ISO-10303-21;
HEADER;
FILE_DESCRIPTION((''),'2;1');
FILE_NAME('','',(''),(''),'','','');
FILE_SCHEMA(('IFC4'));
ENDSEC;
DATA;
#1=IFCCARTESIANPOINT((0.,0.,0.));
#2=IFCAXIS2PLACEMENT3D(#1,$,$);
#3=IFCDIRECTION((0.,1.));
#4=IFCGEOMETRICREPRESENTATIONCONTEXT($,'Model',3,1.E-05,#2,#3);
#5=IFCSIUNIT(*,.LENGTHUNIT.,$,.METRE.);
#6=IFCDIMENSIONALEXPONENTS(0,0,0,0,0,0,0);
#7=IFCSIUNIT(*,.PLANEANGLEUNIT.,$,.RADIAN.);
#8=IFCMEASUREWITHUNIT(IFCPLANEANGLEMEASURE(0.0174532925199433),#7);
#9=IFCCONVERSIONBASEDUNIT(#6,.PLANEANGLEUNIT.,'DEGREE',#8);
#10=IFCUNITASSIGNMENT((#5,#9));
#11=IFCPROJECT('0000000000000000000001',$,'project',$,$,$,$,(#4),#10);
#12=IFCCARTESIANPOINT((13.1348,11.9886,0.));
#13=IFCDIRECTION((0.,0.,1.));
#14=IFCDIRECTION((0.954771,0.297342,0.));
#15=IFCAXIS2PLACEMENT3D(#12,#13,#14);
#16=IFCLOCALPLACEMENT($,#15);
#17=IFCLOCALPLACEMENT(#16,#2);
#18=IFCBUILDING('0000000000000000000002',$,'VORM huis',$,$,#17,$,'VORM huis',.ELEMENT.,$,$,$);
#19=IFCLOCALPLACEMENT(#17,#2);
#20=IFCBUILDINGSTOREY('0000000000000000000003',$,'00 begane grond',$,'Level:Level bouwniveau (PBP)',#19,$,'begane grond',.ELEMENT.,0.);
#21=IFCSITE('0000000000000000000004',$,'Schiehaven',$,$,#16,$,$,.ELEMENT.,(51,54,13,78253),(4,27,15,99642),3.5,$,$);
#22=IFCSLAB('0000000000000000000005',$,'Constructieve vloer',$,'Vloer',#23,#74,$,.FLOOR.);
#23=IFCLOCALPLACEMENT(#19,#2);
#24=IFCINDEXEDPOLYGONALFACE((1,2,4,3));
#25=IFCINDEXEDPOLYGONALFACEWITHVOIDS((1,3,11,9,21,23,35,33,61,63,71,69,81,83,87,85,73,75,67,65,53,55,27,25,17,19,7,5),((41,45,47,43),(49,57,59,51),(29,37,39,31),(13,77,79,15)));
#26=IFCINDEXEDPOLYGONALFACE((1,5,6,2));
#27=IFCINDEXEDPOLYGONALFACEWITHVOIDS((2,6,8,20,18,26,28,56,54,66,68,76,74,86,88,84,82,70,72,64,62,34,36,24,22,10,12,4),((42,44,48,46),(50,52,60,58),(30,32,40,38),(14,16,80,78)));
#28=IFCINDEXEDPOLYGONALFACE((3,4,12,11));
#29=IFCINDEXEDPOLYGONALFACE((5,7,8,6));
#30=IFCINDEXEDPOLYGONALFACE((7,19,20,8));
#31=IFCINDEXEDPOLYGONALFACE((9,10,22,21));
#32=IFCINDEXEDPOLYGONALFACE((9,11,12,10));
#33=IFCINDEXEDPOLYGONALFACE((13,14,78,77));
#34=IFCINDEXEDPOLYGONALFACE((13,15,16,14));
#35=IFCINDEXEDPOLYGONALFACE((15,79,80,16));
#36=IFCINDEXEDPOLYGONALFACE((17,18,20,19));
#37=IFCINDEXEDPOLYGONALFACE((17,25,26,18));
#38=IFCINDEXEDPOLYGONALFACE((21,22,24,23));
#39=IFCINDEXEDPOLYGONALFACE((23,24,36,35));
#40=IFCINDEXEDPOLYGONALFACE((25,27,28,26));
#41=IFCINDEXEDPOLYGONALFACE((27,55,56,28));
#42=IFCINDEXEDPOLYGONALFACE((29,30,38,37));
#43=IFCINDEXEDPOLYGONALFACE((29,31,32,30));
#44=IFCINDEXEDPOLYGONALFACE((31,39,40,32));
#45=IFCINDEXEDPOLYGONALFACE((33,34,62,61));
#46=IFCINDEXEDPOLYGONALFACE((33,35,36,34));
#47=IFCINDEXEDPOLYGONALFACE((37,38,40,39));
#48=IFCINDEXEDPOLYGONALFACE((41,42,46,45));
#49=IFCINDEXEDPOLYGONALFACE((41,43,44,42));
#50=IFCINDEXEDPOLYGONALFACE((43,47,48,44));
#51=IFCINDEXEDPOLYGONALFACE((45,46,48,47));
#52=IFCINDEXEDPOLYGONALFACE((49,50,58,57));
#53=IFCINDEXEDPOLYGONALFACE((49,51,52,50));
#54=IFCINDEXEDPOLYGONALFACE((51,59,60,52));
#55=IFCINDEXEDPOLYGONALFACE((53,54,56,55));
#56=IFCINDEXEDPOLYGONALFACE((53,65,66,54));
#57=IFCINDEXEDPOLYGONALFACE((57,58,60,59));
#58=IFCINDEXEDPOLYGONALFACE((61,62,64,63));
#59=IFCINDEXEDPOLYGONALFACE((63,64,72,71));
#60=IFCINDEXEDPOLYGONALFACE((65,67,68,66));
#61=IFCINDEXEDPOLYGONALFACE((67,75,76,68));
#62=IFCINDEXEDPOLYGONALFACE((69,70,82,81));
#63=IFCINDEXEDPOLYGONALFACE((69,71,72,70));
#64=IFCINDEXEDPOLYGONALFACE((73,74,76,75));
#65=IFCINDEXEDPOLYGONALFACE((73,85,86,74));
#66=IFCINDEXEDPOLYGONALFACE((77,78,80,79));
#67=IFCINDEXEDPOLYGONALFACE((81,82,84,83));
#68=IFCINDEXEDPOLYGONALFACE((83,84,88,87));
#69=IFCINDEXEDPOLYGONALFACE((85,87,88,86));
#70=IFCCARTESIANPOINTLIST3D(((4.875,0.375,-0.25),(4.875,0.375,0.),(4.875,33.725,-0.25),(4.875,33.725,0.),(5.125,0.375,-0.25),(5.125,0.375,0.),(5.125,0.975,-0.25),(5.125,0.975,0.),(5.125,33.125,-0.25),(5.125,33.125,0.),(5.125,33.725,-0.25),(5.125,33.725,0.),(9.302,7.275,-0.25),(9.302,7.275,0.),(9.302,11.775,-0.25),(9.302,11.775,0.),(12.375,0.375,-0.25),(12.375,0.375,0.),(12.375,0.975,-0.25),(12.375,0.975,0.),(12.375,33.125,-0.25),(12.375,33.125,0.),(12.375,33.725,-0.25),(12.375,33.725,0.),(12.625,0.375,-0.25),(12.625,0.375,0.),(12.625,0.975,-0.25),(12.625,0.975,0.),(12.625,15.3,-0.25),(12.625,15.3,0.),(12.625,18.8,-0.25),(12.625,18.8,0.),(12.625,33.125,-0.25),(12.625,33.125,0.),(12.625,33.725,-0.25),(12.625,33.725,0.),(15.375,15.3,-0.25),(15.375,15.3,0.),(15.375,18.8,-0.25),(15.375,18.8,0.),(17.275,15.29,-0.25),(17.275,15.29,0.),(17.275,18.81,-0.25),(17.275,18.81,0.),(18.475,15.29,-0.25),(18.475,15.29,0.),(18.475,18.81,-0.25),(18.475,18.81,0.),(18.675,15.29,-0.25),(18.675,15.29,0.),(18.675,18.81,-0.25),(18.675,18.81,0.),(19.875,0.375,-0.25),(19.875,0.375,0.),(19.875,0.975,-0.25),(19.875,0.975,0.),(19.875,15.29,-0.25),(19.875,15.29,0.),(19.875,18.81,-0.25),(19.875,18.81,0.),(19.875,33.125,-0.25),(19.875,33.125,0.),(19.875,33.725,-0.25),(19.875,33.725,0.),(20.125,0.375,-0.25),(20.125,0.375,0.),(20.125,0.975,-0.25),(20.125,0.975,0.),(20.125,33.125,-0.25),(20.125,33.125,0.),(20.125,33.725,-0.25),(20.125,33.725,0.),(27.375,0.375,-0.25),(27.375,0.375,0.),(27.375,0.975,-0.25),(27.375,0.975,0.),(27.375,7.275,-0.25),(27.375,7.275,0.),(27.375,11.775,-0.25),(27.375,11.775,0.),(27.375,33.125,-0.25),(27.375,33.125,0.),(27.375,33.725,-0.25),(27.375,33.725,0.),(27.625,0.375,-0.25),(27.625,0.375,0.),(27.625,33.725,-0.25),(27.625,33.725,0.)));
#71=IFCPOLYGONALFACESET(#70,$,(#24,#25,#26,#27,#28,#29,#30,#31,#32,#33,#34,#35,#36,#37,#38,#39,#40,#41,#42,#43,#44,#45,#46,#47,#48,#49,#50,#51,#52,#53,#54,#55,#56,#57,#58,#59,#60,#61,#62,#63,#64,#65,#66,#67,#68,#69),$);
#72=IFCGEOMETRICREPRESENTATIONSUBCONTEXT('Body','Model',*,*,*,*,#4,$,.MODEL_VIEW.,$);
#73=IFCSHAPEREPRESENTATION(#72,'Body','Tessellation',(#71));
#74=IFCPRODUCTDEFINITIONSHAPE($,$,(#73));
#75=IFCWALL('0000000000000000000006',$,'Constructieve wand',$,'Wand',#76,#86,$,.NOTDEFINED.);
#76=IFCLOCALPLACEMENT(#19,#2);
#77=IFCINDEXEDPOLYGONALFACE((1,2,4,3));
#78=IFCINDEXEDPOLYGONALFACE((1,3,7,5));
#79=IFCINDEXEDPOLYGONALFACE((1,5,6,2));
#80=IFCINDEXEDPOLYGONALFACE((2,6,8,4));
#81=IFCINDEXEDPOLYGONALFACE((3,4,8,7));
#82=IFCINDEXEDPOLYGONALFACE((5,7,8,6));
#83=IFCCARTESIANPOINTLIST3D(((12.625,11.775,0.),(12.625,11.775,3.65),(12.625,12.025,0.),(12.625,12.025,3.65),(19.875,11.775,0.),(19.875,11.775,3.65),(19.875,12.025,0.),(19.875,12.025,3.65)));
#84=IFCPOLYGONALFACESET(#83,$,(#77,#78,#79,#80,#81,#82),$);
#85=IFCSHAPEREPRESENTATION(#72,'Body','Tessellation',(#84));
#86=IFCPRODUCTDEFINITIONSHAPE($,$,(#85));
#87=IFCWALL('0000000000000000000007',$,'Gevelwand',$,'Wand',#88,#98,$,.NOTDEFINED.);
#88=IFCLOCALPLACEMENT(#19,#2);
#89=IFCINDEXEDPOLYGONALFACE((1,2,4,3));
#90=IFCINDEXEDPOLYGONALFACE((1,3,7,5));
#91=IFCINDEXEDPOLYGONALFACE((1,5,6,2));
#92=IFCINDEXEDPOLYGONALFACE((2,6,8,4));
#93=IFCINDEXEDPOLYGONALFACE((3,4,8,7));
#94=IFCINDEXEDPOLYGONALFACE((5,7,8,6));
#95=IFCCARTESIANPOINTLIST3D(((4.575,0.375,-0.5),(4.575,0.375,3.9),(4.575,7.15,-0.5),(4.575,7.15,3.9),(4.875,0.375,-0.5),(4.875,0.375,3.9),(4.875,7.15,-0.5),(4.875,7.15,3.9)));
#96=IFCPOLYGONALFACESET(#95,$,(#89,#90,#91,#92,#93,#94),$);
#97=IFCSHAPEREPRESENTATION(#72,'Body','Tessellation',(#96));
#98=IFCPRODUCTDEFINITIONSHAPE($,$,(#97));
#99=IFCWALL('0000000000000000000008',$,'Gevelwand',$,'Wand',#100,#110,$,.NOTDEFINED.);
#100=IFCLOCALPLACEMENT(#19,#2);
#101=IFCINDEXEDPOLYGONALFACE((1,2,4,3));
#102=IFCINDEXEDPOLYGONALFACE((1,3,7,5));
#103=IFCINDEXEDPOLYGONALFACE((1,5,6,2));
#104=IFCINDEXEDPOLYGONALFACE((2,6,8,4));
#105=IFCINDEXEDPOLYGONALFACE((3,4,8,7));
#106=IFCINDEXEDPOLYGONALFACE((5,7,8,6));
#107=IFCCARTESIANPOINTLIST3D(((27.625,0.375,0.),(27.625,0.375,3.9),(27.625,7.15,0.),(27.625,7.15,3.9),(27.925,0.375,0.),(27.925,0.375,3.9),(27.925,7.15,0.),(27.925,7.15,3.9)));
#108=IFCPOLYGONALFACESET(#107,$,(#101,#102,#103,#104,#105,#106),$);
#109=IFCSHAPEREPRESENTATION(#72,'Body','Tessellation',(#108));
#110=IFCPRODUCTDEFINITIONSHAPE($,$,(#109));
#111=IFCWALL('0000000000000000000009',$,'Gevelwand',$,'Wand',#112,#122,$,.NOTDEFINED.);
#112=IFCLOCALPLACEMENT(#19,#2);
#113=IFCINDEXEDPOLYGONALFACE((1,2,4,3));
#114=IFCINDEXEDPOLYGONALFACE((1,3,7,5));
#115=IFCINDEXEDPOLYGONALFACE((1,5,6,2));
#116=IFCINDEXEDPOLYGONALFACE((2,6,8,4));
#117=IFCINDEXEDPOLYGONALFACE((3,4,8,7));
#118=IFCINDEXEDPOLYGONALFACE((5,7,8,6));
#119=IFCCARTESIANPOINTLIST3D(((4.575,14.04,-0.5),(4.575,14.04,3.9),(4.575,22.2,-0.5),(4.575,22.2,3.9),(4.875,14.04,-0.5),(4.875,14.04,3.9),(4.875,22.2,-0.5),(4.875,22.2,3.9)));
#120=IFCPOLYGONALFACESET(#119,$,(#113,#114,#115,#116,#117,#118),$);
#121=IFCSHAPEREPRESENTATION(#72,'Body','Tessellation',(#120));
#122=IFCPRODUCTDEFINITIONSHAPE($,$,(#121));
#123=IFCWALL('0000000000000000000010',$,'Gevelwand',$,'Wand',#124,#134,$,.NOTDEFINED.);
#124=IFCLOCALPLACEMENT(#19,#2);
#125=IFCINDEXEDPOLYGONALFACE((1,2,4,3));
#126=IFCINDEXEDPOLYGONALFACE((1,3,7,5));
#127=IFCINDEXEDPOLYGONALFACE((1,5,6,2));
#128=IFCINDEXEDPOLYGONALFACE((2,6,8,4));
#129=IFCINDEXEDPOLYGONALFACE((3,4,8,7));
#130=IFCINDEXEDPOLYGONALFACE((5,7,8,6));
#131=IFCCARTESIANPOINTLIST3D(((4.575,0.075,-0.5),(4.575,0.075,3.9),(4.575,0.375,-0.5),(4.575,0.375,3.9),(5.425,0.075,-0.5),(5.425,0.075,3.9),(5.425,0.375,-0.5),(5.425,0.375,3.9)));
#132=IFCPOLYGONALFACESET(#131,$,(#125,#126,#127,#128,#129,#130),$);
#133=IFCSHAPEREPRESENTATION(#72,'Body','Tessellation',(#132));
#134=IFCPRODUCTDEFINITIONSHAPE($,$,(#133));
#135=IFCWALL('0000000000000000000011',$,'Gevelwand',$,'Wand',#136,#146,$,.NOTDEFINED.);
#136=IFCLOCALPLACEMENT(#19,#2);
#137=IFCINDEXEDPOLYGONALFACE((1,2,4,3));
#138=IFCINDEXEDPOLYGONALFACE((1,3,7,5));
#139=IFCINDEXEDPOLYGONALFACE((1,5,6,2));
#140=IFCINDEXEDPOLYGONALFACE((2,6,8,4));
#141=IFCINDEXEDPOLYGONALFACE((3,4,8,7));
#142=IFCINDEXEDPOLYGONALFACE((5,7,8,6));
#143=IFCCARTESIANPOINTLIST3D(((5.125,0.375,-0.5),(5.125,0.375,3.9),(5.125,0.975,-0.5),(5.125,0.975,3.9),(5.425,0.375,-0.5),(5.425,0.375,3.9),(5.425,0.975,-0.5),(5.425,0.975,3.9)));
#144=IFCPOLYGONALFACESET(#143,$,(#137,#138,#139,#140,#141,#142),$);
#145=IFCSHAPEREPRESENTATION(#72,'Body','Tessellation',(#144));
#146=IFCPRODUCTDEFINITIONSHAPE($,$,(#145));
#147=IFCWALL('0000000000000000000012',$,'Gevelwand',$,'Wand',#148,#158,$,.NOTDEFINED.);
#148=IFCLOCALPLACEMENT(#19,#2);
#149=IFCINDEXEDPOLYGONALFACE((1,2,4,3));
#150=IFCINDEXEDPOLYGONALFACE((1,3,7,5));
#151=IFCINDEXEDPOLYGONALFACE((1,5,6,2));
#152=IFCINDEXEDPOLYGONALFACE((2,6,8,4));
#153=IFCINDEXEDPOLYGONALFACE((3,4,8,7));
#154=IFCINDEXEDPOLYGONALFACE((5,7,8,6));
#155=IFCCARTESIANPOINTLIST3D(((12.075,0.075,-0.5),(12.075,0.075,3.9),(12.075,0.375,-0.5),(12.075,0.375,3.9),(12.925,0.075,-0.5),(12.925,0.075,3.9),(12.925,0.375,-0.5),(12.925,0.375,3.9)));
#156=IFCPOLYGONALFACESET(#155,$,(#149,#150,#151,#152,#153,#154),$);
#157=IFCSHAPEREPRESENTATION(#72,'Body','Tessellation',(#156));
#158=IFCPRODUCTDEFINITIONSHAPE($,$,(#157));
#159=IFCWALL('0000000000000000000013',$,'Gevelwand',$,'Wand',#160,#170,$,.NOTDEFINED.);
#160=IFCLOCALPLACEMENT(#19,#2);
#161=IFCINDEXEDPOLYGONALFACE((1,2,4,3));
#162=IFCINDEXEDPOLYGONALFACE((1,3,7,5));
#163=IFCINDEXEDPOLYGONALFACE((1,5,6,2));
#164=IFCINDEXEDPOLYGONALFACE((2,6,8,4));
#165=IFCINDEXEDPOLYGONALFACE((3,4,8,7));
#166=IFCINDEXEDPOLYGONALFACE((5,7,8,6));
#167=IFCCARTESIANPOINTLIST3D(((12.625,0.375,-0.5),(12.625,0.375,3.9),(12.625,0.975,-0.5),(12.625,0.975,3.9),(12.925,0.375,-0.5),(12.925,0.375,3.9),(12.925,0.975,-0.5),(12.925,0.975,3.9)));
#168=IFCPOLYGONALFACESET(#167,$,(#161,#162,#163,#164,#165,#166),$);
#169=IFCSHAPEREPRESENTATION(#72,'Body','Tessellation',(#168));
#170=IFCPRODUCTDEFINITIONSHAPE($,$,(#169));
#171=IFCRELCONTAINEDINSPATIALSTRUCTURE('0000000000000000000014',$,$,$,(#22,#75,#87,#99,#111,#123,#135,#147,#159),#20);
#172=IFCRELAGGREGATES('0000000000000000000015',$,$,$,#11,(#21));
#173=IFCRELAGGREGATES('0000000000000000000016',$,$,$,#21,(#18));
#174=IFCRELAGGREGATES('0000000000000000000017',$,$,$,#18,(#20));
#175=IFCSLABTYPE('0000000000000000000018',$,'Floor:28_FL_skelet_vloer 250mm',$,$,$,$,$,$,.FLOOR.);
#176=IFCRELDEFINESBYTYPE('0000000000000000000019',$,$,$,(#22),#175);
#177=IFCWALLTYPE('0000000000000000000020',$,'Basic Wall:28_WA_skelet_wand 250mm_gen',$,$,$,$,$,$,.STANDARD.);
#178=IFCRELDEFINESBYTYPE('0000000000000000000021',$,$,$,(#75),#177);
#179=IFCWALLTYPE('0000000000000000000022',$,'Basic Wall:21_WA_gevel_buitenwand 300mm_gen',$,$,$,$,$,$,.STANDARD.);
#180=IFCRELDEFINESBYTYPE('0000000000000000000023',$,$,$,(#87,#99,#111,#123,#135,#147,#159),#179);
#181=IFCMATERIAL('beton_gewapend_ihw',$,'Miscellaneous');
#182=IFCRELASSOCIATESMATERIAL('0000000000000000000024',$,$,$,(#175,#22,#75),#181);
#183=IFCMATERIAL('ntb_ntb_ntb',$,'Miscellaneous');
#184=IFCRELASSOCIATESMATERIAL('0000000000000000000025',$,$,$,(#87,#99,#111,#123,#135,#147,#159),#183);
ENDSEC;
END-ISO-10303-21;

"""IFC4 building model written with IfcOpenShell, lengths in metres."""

from ifc_helpers import new_model, entity, si_unit, converted_unit, direction, frame, origin, place, context, subcontext, project, spatial, indexed_curve, outline, extrude, material, type_object, element, save


model = new_model("IFC4")

# Units and contexts
model_context = context("Model", 3, precision=1e-05, world=origin(), true_north=direction((0.0, 1.0)))
body_context = subcontext(model_context, "Body", "Model", "MODEL_VIEW")
ifc_project = project(units=[si_unit("LENGTHUNIT", "METRE"), converted_unit("PLANEANGLEUNIT", "DEGREE", entity("IfcPlaneAngleMeasure", 0.0174532925199433), si_unit("PLANEANGLEUNIT", "RADIAN"), dimensions=[0, 0, 0, 0, 0, 0, 0])], contexts=[model_context])

# Site, building, storey
site_placement = place(None, frame((13.1348, 11.9886, 0.0), z_axis=(0.0, 0.0, 1.0), x_axis=(0.954771, 0.297342, 0.0)))
site = spatial("IfcSite", under=ifc_project, at=site_placement, Name="Schiehaven", CompositionType="ELEMENT", RefLatitude=(51, 54, 13, 78253), RefLongitude=(4, 27, 15, 99642), RefElevation=3.5)
building_placement = place(site_placement, origin())
building = spatial("IfcBuilding", under=site, at=building_placement, Name="VORM huis", LongName="VORM huis", CompositionType="ELEMENT")
storey_placement = place(building_placement, origin())
storey = spatial("IfcBuildingStorey", under=building, at=storey_placement, Name="00 begane grond", ObjectType="Level:Level bouwniveau (PBP)", LongName="begane grond", CompositionType="ELEMENT", Elevation=0.0)

# Slab, openings
ifc_material_1 = material(Name="beton_gewapend_ihw", Category="Miscellaneous")
slab_type = type_object("IfcSlabType", Name="Floor:28_FL_skelet_vloer 250mm", PredefinedType="FLOOR", material=ifc_material_1)
slab_placement = place(storey_placement, origin())
slab = element("IfcSlab", 1, at=slab_placement, inside=storey, type_object=slab_type, material=ifc_material_1, Name="Constructieve vloer", ObjectType="Vloer", PredefinedType="FLOOR", context=body_context, shape_type="SweptSolid", body=[
    extrude(outline(indexed_curve([(-11.375, -16.675), (-11.125, -16.675), (-11.125, -16.075), (-3.875, -16.075), (-3.875, -16.675), (-3.625, -16.675), (-3.625, -16.075), (3.625, -16.075), (3.625, -16.675), (3.875, -16.675), (3.875, -16.075), (11.125, -16.075), (11.125, -16.675), (11.375, -16.675), (11.375, 16.675), (11.125, 16.675), (11.125, 16.075), (3.875, 16.075), (3.875, 16.675), (3.625, 16.675), (3.625, 16.075), (-3.625, 16.075), (-3.625, 16.675), (-3.875, 16.675), (-3.875, 16.075), (-11.125, 16.075), (-11.125, 16.675), (-11.375, 16.675), (-11.375, -16.675)], self_intersect=False), holes=[indexed_curve([(3.625, -1.75), (0.875, -1.75), (0.875, 1.75), (3.625, 1.75), (3.625, -1.75)], self_intersect=False), indexed_curve([(-11.125, 5.275), (-11.125, 9.775), (6.948, 9.775), (6.948, 5.275), (-11.125, 5.275)], self_intersect=False), indexed_curve([(-2.225, -1.76), (-2.225, 1.76), (-1.025, 1.76), (-1.025, -1.76), (-2.225, -1.76)], self_intersect=False), indexed_curve([(-2.425, 1.76), (-2.425, -1.76), (-3.625, -1.76), (-3.625, 1.76), (-2.425, 1.76)], self_intersect=False)]), frame((16.25, 17.05, -0.25), z_axis=(0.0, 0.0, 1.0), x_axis=(-1.0, 0.0, 0.0)), (0.0, 0.0, 1.0), 0.25),
])
opening_1_placement = place(slab_placement, origin())
element("IfcOpeningElement", 2, at=opening_1_placement, cuts=slab, PredefinedType="OPENING", context=body_context, shape_type="SweptSolid", body=[
    extrude(outline(indexed_curve([(-1.75, -1.375), (1.75, -1.375), (1.75, 1.375), (-1.75, 1.375), (-1.75, -1.375)], self_intersect=False)), frame((14.0, 17.05, -0.25), z_axis=(0.0, 0.0, 1.0), x_axis=(0.0, -1.0, 0.0)), (0.0, 0.0, 1.0), 0.25),
])
opening_2_placement = place(slab_placement, origin())
element("IfcOpeningElement", 3, at=opening_2_placement, cuts=slab, PredefinedType="OPENING", context=body_context, shape_type="SweptSolid", body=[
    extrude(outline(indexed_curve([(-9.0365, -2.25), (9.0365, -2.25), (9.0365, 2.25), (-9.0365, 2.25), (-9.0365, -2.25)], self_intersect=False)), frame((18.3385, 9.525, -0.25), z_axis=(0.0, 0.0, 1.0), x_axis=(-1.0, 0.0, 0.0)), (0.0, 0.0, 1.0), 0.25),
])
opening_3_placement = place(slab_placement, origin())
element("IfcOpeningElement", 4, at=opening_3_placement, cuts=slab, PredefinedType="OPENING", context=body_context, shape_type="SweptSolid", body=[
    extrude(outline(indexed_curve([(-0.6, -1.76), (0.6, -1.76), (0.6, 1.76), (-0.6, 1.76), (-0.6, -1.76)], self_intersect=False)), frame((17.875, 17.05, -0.25), z_axis=(0.0, 0.0, 1.0), x_axis=(-1.0, 0.0, 0.0)), (0.0, 0.0, 1.0), 0.25),
])

# Walls
wall_type_1 = type_object("IfcWallType", Name="Basic Wall:28_WA_skelet_wand 250mm_gen", PredefinedType="STANDARD")
wall_1_placement = place(storey_placement, frame((19.875, 11.9, 0.0), z_axis=(0.0, 0.0, 1.0), x_axis=(-1.0, 0.0, 0.0)))
element("IfcWall", 5, at=wall_1_placement, inside=storey, type_object=wall_type_1, material=ifc_material_1, Name="Constructieve wand", ObjectType="Wand", PredefinedType="NOTDEFINED", context=body_context, shape_type="SweptSolid", body=[
    extrude(outline(indexed_curve([(7.25, 0.125), (0.0, 0.125), (0.0, -0.125), (7.25, -0.125), (7.25, 0.125)], self_intersect=False)), origin(), (0.0, 0.0, 1.0), 3.65),
])
ifc_material_2 = material(Name="ntb_ntb_ntb", Category="Miscellaneous")
wall_type_2 = type_object("IfcWallType", Name="Basic Wall:21_WA_gevel_buitenwand 300mm_gen", PredefinedType="STANDARD")
wall_2_placement = place(storey_placement, frame((4.725, 0.375, -0.5), z_axis=(0.0, 0.0, 1.0), x_axis=(0.0, 1.0, 0.0)))
element("IfcWall", 6, at=wall_2_placement, inside=storey, type_object=wall_type_2, material=ifc_material_2, Name="Gevelwand", ObjectType="Wand", PredefinedType="NOTDEFINED", context=body_context, shape_type="SweptSolid", body=[
    extrude(outline(indexed_curve([(6.775, 0.15), (0.0, 0.15), (0.0, -0.15), (6.775, -0.15), (6.775, 0.15)], self_intersect=False)), origin(), (0.0, 0.0, 1.0), 4.4),
])
wall_3_placement = place(storey_placement, frame((27.775, 7.15, 0.0), z_axis=(0.0, 0.0, 1.0), x_axis=(0.0, -1.0, 0.0)))
element("IfcWall", 7, at=wall_3_placement, inside=storey, type_object=wall_type_2, material=ifc_material_2, Name="Gevelwand", ObjectType="Wand", PredefinedType="NOTDEFINED", context=body_context, shape_type="SweptSolid", body=[
    extrude(outline(indexed_curve([(6.775, 0.15), (0.0, 0.15), (0.0, -0.15), (6.775, -0.15), (6.775, 0.15)], self_intersect=False)), origin(), (0.0, 0.0, 1.0), 3.9),
])
wall_4_placement = place(storey_placement, frame((4.725, 14.04, -0.5), z_axis=(0.0, 0.0, 1.0), x_axis=(0.0, 1.0, 0.0)))
element("IfcWall", 8, at=wall_4_placement, inside=storey, type_object=wall_type_2, material=ifc_material_2, Name="Gevelwand", ObjectType="Wand", PredefinedType="NOTDEFINED", context=body_context, shape_type="SweptSolid", body=[
    extrude(outline(indexed_curve([(8.16, 0.15), (0.0, 0.15), (0.0, -0.15), (8.16, -0.15), (8.16, 0.15)], self_intersect=False)), origin(), (0.0, 0.0, 1.0), 4.4),
])
wall_5_placement = place(storey_placement, frame((5.425, 0.225, -0.5), z_axis=(0.0, 0.0, 1.0), x_axis=(-1.0, 0.0, 0.0)))
element("IfcWall", 9, at=wall_5_placement, inside=storey, type_object=wall_type_2, material=ifc_material_2, Name="Gevelwand", ObjectType="Wand", PredefinedType="NOTDEFINED", context=body_context, shape_type="SweptSolid", body=[
    extrude(outline(indexed_curve([(0.85, 0.15), (0.0, 0.15), (0.0, -0.15), (0.85, -0.15), (0.85, 0.15)], self_intersect=False)), origin(), (0.0, 0.0, 1.0), 4.4),
])
wall_6_placement = place(storey_placement, frame((5.275, 0.975, -0.5), z_axis=(0.0, 0.0, 1.0), x_axis=(0.0, -1.0, 0.0)))
element("IfcWall", 10, at=wall_6_placement, inside=storey, type_object=wall_type_2, material=ifc_material_2, Name="Gevelwand", ObjectType="Wand", PredefinedType="NOTDEFINED", context=body_context, shape_type="SweptSolid", body=[
    extrude(outline(indexed_curve([(0.6, 0.15), (0.0, 0.15), (0.0, -0.15), (0.6, -0.15), (0.6, 0.15)], self_intersect=False)), origin(), (0.0, 0.0, 1.0), 4.4),
])
wall_7_placement = place(storey_placement, frame((12.925, 0.225, -0.5), z_axis=(0.0, 0.0, 1.0), x_axis=(-1.0, 0.0, 0.0)))
element("IfcWall", 11, at=wall_7_placement, inside=storey, type_object=wall_type_2, material=ifc_material_2, Name="Gevelwand", ObjectType="Wand", PredefinedType="NOTDEFINED", context=body_context, shape_type="SweptSolid", body=[
    extrude(outline(indexed_curve([(0.85, 0.15), (0.0, 0.15), (0.0, -0.15), (0.85, -0.15), (0.85, 0.15)], self_intersect=False)), origin(), (0.0, 0.0, 1.0), 4.4),
])
wall_8_placement = place(storey_placement, frame((12.775, 0.975, -0.5), z_axis=(0.0, 0.0, 1.0), x_axis=(0.0, -1.0, 0.0)))
element("IfcWall", 12, at=wall_8_placement, inside=storey, type_object=wall_type_2, material=ifc_material_2, Name="Gevelwand", ObjectType="Wand", PredefinedType="NOTDEFINED", context=body_context, shape_type="SweptSolid", body=[
    extrude(outline(indexed_curve([(0.6, 0.15), (0.0, 0.15), (0.0, -0.15), (0.6, -0.15), (0.6, 0.15)], self_intersect=False)), origin(), (0.0, 0.0, 1.0), 4.4),
])

save(model, "model.ifc")
